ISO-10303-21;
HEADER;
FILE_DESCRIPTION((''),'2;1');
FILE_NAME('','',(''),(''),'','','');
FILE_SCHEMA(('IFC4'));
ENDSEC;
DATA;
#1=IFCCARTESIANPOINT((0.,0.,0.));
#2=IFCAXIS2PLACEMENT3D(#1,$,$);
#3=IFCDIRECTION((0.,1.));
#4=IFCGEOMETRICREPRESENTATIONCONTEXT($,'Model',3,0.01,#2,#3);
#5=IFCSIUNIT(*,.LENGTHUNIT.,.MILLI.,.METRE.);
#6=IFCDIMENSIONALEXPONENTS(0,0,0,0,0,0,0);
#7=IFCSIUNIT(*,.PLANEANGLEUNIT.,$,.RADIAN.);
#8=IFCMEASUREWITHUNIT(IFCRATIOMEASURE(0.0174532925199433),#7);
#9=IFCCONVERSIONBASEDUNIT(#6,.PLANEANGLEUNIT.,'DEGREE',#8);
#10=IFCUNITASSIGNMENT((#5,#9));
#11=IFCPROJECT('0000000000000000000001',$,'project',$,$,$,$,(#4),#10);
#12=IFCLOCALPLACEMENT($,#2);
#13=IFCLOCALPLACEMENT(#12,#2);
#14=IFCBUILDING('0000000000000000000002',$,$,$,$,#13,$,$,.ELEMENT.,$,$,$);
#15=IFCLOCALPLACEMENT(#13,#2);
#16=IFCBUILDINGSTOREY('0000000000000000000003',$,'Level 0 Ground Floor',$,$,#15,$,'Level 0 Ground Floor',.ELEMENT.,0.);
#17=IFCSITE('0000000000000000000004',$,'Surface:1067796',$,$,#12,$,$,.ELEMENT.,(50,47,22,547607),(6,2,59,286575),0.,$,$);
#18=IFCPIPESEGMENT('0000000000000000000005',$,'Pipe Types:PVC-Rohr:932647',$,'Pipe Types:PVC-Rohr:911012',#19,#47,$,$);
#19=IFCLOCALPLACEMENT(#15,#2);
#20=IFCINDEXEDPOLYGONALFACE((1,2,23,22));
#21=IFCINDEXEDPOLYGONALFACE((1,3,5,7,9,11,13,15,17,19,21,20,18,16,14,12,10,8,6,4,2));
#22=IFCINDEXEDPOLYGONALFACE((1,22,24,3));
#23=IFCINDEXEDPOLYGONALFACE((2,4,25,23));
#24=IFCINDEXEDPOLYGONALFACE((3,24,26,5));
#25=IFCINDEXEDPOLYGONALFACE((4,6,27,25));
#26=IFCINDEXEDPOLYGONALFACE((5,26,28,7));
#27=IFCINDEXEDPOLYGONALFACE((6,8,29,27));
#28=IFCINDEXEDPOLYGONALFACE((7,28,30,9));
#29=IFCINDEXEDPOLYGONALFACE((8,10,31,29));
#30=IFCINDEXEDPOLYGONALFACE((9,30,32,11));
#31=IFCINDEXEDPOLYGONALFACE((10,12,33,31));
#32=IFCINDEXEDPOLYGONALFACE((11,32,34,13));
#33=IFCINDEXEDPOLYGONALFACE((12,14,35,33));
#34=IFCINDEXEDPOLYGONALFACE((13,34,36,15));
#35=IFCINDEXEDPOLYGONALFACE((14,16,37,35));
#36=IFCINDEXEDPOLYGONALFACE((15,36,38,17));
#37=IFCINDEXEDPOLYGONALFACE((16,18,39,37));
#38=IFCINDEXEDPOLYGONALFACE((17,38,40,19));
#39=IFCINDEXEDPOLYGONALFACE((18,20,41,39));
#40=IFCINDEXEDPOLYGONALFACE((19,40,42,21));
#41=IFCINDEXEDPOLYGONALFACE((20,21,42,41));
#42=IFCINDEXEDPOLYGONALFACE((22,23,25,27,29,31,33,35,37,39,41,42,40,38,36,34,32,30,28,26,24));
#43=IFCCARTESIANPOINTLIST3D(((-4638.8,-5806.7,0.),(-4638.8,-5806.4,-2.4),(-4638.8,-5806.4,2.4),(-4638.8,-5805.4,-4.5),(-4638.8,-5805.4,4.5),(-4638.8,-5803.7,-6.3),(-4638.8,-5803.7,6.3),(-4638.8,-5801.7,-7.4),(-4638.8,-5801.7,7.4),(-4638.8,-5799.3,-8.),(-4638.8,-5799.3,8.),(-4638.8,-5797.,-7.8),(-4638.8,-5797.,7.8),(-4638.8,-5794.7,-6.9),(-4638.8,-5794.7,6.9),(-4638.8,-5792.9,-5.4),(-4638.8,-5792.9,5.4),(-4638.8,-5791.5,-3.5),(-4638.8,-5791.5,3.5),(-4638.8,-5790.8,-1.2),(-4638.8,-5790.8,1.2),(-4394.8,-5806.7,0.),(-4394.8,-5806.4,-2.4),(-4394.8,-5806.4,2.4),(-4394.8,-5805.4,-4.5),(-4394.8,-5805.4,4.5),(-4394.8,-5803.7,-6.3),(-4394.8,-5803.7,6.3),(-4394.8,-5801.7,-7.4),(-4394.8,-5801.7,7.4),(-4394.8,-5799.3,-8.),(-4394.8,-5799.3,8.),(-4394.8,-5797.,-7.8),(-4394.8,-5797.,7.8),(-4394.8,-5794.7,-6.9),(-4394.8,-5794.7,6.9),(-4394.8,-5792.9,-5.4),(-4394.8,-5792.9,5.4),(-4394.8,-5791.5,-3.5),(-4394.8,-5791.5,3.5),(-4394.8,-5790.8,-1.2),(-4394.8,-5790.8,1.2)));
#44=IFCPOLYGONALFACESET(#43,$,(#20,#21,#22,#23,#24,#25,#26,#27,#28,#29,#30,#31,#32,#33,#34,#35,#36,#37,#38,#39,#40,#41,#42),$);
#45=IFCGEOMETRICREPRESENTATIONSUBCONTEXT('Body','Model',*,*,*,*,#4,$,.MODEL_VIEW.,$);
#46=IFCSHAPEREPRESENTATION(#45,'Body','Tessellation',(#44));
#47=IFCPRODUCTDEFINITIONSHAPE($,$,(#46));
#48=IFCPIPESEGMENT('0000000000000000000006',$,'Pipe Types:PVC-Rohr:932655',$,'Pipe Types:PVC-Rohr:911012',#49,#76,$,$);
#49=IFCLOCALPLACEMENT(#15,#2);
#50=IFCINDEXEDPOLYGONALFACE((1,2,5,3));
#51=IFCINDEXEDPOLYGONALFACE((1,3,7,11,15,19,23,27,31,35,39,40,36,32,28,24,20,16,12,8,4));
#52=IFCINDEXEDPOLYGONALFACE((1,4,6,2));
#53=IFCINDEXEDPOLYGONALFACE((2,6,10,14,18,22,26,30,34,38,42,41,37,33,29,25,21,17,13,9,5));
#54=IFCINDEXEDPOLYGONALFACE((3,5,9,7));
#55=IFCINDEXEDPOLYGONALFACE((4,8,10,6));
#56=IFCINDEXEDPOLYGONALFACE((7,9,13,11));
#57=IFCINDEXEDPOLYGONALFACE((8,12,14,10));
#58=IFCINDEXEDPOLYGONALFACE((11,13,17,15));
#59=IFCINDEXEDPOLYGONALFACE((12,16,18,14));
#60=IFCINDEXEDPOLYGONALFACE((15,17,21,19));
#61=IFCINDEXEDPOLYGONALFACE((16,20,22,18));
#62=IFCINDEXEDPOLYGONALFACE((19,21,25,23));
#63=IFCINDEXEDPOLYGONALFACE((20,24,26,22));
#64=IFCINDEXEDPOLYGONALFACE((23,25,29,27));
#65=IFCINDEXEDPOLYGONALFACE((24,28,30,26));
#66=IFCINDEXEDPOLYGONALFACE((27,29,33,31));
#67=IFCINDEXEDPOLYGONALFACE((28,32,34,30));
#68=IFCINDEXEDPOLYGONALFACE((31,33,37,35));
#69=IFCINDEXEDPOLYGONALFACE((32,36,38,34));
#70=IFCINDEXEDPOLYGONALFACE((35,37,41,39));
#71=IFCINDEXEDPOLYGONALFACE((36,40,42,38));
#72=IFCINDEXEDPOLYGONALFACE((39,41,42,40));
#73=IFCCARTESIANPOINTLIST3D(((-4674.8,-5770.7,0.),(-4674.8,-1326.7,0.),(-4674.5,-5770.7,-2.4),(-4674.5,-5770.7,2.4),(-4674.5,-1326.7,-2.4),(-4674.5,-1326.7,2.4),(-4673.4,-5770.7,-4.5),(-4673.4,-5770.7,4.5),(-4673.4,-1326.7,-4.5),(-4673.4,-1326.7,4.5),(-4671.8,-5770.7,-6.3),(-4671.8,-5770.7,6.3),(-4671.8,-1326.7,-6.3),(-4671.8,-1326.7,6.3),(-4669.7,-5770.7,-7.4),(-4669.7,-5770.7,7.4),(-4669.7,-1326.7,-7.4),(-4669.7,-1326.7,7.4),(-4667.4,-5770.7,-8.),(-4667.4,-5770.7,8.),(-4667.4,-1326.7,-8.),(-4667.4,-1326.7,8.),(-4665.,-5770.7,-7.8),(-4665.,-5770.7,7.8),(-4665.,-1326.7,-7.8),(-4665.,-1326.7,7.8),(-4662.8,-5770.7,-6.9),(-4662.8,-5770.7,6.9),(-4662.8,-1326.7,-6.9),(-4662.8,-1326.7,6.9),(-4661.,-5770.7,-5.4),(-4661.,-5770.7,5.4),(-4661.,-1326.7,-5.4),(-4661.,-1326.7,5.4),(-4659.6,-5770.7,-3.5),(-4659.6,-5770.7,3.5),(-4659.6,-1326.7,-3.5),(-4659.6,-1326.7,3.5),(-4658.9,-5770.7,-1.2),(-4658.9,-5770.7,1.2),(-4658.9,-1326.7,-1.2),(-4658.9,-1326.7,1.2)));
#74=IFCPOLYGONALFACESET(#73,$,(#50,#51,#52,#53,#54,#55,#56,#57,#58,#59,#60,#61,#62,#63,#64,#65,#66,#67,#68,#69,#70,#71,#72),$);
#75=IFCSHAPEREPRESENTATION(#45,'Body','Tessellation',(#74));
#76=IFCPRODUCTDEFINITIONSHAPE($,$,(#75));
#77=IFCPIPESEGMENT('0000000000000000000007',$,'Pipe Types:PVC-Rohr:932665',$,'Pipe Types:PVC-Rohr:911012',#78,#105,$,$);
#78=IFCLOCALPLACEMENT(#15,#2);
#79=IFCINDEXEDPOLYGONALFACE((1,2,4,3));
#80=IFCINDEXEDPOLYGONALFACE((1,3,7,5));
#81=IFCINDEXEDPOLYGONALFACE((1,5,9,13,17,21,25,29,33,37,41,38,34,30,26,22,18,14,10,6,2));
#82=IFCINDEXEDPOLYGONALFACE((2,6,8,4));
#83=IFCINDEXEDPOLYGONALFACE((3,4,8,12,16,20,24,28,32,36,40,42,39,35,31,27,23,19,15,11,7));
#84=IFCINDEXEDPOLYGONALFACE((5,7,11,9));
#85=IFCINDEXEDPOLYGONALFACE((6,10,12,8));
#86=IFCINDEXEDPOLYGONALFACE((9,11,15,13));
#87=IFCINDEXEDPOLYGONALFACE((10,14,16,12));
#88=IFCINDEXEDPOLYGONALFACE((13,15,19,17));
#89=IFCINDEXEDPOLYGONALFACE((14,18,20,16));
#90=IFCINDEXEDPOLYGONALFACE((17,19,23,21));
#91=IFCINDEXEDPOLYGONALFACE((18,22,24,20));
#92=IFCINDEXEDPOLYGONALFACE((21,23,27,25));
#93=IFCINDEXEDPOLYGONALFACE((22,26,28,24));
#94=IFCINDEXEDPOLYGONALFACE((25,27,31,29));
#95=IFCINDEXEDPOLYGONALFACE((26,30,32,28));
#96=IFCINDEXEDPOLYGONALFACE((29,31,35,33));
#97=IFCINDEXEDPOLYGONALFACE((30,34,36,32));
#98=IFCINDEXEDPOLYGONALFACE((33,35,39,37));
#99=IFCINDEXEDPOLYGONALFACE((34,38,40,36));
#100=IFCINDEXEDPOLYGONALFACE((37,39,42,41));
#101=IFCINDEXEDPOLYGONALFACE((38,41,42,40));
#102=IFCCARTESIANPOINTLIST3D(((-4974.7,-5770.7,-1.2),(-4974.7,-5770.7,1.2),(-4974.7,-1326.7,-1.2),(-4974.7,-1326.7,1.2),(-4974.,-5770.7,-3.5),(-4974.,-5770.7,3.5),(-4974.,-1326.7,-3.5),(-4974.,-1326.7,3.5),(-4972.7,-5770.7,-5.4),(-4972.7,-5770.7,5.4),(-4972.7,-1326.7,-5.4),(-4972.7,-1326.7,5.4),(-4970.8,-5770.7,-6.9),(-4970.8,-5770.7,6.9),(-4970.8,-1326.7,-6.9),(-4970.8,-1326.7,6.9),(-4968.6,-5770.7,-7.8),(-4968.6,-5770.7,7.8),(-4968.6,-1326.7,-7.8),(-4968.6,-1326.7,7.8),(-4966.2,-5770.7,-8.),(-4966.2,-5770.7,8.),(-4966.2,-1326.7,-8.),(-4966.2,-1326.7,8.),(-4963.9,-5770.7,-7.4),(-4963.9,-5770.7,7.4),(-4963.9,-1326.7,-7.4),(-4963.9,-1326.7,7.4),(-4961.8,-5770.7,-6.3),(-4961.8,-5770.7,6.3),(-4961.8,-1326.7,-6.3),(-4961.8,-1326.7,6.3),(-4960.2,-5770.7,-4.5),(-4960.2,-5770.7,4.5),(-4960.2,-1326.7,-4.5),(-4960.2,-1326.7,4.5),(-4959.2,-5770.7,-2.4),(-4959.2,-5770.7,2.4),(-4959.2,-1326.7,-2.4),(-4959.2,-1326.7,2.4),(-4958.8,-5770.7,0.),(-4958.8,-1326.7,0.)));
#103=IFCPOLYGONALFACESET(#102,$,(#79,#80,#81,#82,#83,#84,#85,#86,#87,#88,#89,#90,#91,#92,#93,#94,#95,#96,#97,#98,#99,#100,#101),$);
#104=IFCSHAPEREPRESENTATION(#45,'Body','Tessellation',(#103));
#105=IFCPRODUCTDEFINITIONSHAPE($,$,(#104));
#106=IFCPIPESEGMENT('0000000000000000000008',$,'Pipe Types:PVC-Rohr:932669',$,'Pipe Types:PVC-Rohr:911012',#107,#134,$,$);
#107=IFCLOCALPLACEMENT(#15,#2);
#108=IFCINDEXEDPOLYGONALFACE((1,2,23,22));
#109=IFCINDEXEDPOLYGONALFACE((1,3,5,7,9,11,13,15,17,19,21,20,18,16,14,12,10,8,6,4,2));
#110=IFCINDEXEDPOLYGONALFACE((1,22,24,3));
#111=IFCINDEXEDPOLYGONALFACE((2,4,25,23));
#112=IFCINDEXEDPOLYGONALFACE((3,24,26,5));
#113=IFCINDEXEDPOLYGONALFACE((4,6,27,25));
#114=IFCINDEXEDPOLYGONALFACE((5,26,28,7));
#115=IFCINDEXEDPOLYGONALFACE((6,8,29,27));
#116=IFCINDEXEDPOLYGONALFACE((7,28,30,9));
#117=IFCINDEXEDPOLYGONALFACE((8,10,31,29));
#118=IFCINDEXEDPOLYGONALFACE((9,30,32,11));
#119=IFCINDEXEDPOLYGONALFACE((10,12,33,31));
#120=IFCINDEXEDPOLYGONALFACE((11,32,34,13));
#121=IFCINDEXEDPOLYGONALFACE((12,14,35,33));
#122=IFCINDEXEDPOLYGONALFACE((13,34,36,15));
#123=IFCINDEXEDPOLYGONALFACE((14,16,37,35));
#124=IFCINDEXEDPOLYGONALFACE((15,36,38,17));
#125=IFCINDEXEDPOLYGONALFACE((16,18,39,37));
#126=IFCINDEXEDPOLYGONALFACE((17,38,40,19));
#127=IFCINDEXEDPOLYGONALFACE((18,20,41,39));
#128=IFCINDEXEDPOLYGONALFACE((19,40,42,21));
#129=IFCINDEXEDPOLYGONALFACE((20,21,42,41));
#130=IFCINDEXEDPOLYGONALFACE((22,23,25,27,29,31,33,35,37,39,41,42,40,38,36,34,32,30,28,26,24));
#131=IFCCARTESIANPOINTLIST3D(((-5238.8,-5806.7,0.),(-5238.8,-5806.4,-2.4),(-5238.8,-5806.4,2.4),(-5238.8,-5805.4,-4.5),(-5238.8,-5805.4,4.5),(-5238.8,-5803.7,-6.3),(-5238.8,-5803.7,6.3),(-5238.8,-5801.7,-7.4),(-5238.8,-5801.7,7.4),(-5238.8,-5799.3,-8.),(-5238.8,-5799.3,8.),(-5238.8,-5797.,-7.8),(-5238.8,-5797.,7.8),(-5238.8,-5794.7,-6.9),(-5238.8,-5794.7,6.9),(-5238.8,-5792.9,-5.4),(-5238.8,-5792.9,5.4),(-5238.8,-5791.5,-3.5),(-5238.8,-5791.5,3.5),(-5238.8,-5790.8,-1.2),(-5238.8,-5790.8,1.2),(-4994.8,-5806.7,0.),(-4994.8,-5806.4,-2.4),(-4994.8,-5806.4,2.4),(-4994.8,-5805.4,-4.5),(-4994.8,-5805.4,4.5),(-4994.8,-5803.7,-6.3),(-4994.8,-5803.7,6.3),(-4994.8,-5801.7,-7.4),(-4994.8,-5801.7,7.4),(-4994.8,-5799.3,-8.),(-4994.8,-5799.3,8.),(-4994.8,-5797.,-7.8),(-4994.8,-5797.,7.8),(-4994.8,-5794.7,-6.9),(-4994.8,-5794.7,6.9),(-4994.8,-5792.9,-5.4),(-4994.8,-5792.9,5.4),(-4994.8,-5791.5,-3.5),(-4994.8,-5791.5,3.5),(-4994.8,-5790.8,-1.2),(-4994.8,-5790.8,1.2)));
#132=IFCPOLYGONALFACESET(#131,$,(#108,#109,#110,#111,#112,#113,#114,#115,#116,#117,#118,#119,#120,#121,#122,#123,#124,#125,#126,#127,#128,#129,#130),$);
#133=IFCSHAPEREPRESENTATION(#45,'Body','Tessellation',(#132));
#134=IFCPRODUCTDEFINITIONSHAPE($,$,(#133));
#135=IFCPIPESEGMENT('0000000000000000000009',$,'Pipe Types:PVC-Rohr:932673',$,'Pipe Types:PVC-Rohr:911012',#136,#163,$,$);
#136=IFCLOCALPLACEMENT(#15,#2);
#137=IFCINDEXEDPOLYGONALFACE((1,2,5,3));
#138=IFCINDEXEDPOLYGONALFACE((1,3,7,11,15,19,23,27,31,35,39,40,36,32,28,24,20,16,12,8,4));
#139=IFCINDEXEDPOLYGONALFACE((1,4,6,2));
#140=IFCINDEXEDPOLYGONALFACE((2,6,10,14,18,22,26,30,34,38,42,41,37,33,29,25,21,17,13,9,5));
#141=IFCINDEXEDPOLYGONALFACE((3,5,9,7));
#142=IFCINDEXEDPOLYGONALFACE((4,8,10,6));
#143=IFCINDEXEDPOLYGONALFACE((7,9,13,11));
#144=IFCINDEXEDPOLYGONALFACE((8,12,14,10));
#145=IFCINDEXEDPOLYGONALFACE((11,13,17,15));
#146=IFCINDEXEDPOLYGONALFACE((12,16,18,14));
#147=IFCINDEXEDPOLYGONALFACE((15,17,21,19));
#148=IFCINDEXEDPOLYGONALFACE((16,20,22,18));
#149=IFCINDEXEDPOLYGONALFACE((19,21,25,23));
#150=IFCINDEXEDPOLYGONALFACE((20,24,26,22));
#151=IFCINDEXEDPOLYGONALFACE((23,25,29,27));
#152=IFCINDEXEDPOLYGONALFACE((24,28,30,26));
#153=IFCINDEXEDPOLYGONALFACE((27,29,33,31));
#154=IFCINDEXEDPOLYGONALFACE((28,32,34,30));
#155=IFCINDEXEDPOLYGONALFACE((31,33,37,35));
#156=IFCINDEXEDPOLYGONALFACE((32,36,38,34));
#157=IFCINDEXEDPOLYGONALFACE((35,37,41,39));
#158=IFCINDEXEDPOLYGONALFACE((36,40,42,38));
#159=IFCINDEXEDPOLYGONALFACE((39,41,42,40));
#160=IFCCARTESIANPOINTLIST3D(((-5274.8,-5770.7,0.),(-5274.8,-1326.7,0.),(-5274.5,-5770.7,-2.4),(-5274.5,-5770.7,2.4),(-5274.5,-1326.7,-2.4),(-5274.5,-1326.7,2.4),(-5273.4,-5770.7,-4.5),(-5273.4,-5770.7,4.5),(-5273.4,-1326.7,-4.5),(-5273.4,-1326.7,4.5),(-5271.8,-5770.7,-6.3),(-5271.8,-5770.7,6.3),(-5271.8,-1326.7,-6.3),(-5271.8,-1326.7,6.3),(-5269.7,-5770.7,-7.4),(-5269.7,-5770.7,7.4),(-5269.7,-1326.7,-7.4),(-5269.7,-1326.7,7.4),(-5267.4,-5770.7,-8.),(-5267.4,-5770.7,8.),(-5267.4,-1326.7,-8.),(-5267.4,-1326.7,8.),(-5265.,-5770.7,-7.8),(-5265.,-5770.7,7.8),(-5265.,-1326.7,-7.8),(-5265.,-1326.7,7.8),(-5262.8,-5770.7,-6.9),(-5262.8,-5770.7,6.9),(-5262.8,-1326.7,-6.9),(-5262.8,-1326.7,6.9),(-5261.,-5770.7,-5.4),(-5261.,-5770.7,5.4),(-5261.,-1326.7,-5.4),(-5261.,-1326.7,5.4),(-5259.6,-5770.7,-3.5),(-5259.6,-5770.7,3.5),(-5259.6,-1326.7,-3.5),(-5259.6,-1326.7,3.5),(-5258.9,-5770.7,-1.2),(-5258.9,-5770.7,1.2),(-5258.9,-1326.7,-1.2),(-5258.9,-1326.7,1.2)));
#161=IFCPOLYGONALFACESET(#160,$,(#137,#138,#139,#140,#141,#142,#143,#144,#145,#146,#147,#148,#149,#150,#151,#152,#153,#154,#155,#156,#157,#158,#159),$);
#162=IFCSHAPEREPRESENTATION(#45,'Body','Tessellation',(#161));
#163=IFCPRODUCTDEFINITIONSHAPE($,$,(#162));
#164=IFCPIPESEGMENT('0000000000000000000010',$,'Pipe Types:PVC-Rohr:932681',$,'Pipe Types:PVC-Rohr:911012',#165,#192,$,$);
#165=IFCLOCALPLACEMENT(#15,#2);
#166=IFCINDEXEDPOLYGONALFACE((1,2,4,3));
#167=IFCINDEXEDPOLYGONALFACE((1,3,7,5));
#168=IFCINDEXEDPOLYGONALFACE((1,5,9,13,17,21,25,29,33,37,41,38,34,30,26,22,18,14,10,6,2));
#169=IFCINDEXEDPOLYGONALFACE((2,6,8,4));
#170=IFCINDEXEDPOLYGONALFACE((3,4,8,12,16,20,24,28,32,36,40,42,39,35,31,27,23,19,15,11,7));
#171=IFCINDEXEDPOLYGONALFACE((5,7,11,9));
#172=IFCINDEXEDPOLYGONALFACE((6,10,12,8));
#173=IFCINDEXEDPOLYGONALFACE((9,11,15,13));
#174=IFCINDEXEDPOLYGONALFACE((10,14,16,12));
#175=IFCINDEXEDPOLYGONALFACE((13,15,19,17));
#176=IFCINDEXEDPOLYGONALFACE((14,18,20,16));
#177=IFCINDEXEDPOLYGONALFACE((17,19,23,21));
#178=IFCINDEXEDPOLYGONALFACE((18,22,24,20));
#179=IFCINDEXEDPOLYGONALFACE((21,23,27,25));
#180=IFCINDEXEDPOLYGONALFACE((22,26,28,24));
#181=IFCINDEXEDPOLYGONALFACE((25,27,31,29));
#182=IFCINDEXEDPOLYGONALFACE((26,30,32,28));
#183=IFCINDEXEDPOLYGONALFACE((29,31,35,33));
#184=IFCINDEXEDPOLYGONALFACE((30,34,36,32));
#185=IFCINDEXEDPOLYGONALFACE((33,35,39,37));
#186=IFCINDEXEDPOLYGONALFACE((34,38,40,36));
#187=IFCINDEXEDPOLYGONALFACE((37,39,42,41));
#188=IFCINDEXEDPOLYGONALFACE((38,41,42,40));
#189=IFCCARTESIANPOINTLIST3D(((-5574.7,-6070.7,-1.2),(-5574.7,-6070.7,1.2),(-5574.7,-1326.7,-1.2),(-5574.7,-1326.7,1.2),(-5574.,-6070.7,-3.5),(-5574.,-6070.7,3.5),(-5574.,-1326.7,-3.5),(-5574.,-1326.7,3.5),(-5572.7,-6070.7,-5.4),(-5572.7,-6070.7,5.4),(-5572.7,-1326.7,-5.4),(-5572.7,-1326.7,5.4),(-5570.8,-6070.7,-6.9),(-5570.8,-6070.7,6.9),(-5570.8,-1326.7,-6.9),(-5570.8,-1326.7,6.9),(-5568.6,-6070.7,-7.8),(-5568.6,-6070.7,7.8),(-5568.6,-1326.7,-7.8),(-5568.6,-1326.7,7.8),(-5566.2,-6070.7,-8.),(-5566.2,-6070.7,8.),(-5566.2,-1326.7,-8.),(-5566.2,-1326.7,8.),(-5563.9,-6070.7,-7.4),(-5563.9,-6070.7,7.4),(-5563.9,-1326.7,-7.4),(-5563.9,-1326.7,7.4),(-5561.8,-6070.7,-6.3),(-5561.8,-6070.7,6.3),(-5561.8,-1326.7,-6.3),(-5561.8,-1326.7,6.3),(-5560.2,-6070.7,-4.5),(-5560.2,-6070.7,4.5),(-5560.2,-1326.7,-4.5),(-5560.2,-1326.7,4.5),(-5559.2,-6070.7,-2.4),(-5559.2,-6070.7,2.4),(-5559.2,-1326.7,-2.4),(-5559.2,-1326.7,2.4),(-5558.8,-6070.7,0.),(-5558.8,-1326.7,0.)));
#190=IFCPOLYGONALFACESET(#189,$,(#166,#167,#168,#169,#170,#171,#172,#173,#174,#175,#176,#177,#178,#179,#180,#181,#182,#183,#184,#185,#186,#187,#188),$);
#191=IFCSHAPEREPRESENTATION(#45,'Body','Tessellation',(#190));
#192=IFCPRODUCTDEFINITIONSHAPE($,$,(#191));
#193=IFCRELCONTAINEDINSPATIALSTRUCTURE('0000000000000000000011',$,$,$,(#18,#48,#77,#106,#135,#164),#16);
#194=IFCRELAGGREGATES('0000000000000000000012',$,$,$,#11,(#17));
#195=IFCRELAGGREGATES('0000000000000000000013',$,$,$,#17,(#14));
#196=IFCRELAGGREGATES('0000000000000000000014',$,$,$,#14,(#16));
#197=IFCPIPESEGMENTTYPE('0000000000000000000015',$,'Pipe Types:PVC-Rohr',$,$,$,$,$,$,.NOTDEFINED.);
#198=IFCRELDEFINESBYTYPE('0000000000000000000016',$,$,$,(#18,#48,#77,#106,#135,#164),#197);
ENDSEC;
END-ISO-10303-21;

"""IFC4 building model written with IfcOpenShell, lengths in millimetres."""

from ifc_helpers import new_model, entity, si_unit, converted_unit, direction, frame, frame_2d, origin, place, context, subcontext, project, spatial, circle, extrude, type_object, element, save


model = new_model("IFC4")

# Units and contexts
model_context = context("Model", 3, precision=0.01, world=origin(), true_north=direction((0.0, 1.0)))
body_context = subcontext(model_context, "Body", "Model", "MODEL_VIEW")
ifc_project = project(units=[si_unit("LENGTHUNIT", "METRE", prefix="MILLI"), converted_unit("PLANEANGLEUNIT", "DEGREE", entity("IfcRatioMeasure", 0.0174532925199433), si_unit("PLANEANGLEUNIT", "RADIAN"), dimensions=[0, 0, 0, 0, 0, 0, 0])], contexts=[model_context])

# Site, building, storey
site_placement = place(None, origin())
site = spatial("IfcSite", under=ifc_project, at=site_placement, Name="Surface:1067796", CompositionType="ELEMENT", RefLatitude=(50, 47, 22, 547607), RefLongitude=(6, 2, 59, 286575), RefElevation=0.0)
building_placement = place(site_placement, origin())
building = spatial("IfcBuilding", under=site, at=building_placement, CompositionType="ELEMENT")
storey_placement = place(building_placement, origin())
storey = spatial("IfcBuildingStorey", under=building, at=storey_placement, Name="Level 0 Ground Floor", LongName="Level 0 Ground Floor", CompositionType="ELEMENT", Elevation=0.0)

# Pipe segments
pipe_segment_type_1 = type_object("IfcPipeSegmentType", Name="Pipe Types:PVC-Rohr", PredefinedType="NOTDEFINED")
pipe_segment_1_placement = place(storey_placement, frame((-4638.8, -5808.3, -9.6)))
element("IfcPipeSegment", 1, at=pipe_segment_1_placement, inside=storey, type_object=pipe_segment_type_1, Name="Pipe Types:PVC-Rohr:932647", ObjectType="Pipe Types:PVC-Rohr:911012", context=body_context, shape_type="SweptSolid", body=[
    extrude(circle(Radius=8.0, at=frame_2d((0.0, 0.0), x_axis=(1.0, 0.0))), frame((0.0, 9.6, 9.6), z_axis=(1.0, 0.0, 0.0), x_axis=(0.0, -1.0, 0.0)), (0.0, 0.0, 1.0), 244.0),
])
pipe_segment_2_placement = place(storey_placement, frame((-4676.4, -5770.7, -9.6)))
element("IfcPipeSegment", 2, at=pipe_segment_2_placement, inside=storey, type_object=pipe_segment_type_1, Name="Pipe Types:PVC-Rohr:932655", ObjectType="Pipe Types:PVC-Rohr:911012", context=body_context, shape_type="SweptSolid", body=[
    extrude(circle(Radius=8.0, at=frame_2d((0.0, 0.0), x_axis=(1.0, 0.0))), frame((9.6, 0.0, 9.6), z_axis=(0.0, 1.0, 0.0), x_axis=(-1.0, 0.0, 0.0)), (0.0, 0.0, 1.0), 4444.0),
])
pipe_segment_3_placement = place(storey_placement, frame((-4976.4, -5770.7, -9.6)))
element("IfcPipeSegment", 3, at=pipe_segment_3_placement, inside=storey, type_object=pipe_segment_type_1, Name="Pipe Types:PVC-Rohr:932665", ObjectType="Pipe Types:PVC-Rohr:911012", context=body_context, shape_type="SweptSolid", body=[
    extrude(circle(Radius=8.0, at=frame_2d((0.0, 0.0), x_axis=(1.0, 0.0))), frame((9.6, 0.0, 9.6), z_axis=(0.0, 1.0, 0.0), x_axis=(1.0, 0.0, 0.0)), (0.0, 0.0, 1.0), 4444.0),
])
pipe_segment_4_placement = place(storey_placement, frame((-5238.8, -5808.3, -9.6)))
element("IfcPipeSegment", 4, at=pipe_segment_4_placement, inside=storey, type_object=pipe_segment_type_1, Name="Pipe Types:PVC-Rohr:932669", ObjectType="Pipe Types:PVC-Rohr:911012", context=body_context, shape_type="SweptSolid", body=[
    extrude(circle(Radius=8.0, at=frame_2d((0.0, 0.0), x_axis=(1.0, 0.0))), frame((0.0, 9.6, 9.6), z_axis=(1.0, 0.0, 0.0), x_axis=(0.0, -1.0, 0.0)), (0.0, 0.0, 1.0), 244.0),
])
pipe_segment_5_placement = place(storey_placement, frame((-5276.4, -5770.7, -9.6)))
element("IfcPipeSegment", 5, at=pipe_segment_5_placement, inside=storey, type_object=pipe_segment_type_1, Name="Pipe Types:PVC-Rohr:932673", ObjectType="Pipe Types:PVC-Rohr:911012", context=body_context, shape_type="SweptSolid", body=[
    extrude(circle(Radius=8.0, at=frame_2d((0.0, 0.0), x_axis=(1.0, 0.0))), frame((9.6, 0.0, 9.6), z_axis=(0.0, 1.0, 0.0), x_axis=(-1.0, 0.0, 0.0)), (0.0, 0.0, 1.0), 4444.0),
])
pipe_segment_6_placement = place(storey_placement, frame((-5576.4, -6070.7, -9.6)))
element("IfcPipeSegment", 6, at=pipe_segment_6_placement, inside=storey, type_object=pipe_segment_type_1, Name="Pipe Types:PVC-Rohr:932681", ObjectType="Pipe Types:PVC-Rohr:911012", context=body_context, shape_type="SweptSolid", body=[
    extrude(circle(Radius=8.0, at=frame_2d((0.0, 0.0), x_axis=(1.0, 0.0))), frame((9.6, 0.0, 9.6), z_axis=(0.0, 1.0, 0.0), x_axis=(1.0, 0.0, 0.0)), (0.0, 0.0, 1.0), 4744.0),
])

save(model, "model.ifc")
